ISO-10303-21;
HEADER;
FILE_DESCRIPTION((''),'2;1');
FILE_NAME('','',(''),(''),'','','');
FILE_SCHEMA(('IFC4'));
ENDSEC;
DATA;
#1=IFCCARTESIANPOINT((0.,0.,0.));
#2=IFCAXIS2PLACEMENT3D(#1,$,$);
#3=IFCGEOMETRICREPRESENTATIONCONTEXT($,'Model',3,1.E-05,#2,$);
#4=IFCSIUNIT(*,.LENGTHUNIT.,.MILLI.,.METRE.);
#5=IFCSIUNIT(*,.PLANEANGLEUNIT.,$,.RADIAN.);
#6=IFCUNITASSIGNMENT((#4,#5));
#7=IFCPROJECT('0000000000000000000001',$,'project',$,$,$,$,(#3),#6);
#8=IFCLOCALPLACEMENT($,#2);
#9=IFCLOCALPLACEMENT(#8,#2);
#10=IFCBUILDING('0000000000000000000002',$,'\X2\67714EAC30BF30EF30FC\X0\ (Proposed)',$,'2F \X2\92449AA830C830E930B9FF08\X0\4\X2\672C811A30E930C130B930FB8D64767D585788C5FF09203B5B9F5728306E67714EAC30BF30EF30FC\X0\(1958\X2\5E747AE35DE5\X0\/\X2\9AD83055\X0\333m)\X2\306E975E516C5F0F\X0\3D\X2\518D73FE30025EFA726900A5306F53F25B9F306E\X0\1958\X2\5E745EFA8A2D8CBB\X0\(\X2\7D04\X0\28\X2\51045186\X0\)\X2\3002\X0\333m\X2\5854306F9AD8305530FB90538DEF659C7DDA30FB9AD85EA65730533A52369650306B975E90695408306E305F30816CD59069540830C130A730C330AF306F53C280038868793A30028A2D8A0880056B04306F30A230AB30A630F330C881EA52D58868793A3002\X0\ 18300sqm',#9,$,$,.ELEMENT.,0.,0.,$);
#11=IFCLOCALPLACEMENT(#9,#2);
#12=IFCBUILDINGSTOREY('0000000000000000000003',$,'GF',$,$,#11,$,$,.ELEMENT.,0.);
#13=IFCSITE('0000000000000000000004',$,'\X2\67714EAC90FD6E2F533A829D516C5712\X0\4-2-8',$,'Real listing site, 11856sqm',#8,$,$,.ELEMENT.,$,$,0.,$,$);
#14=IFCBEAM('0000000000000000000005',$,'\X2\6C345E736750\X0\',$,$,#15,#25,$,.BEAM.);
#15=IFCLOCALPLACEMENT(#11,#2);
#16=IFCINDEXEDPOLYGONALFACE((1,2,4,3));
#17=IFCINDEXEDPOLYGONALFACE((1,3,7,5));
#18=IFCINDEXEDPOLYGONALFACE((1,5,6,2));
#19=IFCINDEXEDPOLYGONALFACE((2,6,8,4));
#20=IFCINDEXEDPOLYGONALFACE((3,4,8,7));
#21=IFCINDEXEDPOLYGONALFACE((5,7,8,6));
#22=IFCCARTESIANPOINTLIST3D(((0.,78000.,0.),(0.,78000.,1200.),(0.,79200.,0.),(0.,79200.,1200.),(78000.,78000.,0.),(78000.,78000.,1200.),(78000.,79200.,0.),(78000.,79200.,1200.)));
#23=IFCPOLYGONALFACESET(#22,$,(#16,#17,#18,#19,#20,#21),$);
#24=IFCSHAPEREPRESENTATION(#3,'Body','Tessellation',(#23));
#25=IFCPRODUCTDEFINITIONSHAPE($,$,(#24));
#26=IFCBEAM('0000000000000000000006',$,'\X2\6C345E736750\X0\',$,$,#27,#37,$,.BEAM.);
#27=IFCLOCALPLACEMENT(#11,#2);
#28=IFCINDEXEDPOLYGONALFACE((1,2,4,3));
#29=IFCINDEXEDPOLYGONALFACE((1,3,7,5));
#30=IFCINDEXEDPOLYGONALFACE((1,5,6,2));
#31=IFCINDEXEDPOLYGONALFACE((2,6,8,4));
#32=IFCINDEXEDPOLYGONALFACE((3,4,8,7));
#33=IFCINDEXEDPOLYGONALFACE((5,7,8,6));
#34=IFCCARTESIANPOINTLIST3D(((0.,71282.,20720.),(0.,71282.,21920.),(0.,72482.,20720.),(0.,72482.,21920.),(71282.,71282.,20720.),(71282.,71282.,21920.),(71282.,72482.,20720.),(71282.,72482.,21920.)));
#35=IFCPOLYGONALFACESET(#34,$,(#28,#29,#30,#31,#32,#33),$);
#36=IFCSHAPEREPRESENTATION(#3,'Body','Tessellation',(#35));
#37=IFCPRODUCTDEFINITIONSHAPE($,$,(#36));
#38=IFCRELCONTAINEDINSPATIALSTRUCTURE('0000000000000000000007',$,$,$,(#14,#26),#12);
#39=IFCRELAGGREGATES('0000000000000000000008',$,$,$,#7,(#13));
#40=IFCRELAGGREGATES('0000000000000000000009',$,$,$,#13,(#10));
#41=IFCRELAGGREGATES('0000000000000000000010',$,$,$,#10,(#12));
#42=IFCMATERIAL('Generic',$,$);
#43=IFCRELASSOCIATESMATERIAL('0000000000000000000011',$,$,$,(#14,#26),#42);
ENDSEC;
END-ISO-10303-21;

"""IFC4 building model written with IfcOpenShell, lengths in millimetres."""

from ifc_helpers import new_model, si_unit, frame, frame_2d, origin, place, context, project, spatial, rectangle, extrude, material, element, save


model = new_model("IFC4")

# Units and contexts
model_context = context("Model", 3, precision=1e-05, world=origin())
ifc_project = project(units=[si_unit("LENGTHUNIT", "METRE", prefix="MILLI"), si_unit("PLANEANGLEUNIT", "RADIAN")], contexts=[model_context])

# Site, building, storey
site_placement = place(None, origin())
site = spatial("IfcSite", under=ifc_project, at=site_placement, Name="東京都港区芝公園4-2-8", ObjectType="Real listing site, 11856sqm", CompositionType="ELEMENT", RefElevation=0.0)
building_placement = place(site_placement, origin())
building = spatial("IfcBuilding", under=site, at=building_placement, Name="東京タワー (Proposed)", ObjectType="2F 鉄骨トラス（4本脚ラチス・赤白塗装）※実在の東京タワー(1958年竣工/高さ333m)の非公式3D再現。建物¥は史実の1958年建設費(約28億円)。333m塔は高さ・道路斜線・高度地区制限に非適合のため法適合チェックは参考表示。設計者欄はアカウント自動表示。 18300sqm", CompositionType="ELEMENT", ElevationOfRefHeight=0.0, ElevationOfTerrain=0.0)
storey_placement = place(building_placement, origin())
storey = spatial("IfcBuildingStorey", under=building, at=storey_placement, Name="GF", CompositionType="ELEMENT", Elevation=0.0)

# Shared definitions
ifc_material = material(Name="Generic")

# Beams
beam_1_placement = place(storey_placement, frame((0.0, 39000.0, 0.0)))
element("IfcBeam", 1, at=beam_1_placement, inside=storey, material=ifc_material, Name="水平材", PredefinedType="BEAM", context=model_context, shape_type="SweptSolid", body=[
    extrude(rectangle(XDim=78000.0, YDim=1200.0, at=frame_2d((39000.0, 600.0))), frame((0.0, 39000.0, 0.0)), (0.0, 0.0, 1.0), 1200.0),
])
beam_2_placement = place(storey_placement, frame((0.0, 35641.0, 10360.0)))
element("IfcBeam", 2, at=beam_2_placement, inside=storey, material=ifc_material, Name="水平材", PredefinedType="BEAM", context=model_context, shape_type="SweptSolid", body=[
    extrude(rectangle(XDim=71282.0, YDim=1200.0, at=frame_2d((35641.0, 600.0))), frame((0.0, 35641.0, 10360.0)), (0.0, 0.0, 1.0), 1200.0),
])

save(model, "model.ifc")
